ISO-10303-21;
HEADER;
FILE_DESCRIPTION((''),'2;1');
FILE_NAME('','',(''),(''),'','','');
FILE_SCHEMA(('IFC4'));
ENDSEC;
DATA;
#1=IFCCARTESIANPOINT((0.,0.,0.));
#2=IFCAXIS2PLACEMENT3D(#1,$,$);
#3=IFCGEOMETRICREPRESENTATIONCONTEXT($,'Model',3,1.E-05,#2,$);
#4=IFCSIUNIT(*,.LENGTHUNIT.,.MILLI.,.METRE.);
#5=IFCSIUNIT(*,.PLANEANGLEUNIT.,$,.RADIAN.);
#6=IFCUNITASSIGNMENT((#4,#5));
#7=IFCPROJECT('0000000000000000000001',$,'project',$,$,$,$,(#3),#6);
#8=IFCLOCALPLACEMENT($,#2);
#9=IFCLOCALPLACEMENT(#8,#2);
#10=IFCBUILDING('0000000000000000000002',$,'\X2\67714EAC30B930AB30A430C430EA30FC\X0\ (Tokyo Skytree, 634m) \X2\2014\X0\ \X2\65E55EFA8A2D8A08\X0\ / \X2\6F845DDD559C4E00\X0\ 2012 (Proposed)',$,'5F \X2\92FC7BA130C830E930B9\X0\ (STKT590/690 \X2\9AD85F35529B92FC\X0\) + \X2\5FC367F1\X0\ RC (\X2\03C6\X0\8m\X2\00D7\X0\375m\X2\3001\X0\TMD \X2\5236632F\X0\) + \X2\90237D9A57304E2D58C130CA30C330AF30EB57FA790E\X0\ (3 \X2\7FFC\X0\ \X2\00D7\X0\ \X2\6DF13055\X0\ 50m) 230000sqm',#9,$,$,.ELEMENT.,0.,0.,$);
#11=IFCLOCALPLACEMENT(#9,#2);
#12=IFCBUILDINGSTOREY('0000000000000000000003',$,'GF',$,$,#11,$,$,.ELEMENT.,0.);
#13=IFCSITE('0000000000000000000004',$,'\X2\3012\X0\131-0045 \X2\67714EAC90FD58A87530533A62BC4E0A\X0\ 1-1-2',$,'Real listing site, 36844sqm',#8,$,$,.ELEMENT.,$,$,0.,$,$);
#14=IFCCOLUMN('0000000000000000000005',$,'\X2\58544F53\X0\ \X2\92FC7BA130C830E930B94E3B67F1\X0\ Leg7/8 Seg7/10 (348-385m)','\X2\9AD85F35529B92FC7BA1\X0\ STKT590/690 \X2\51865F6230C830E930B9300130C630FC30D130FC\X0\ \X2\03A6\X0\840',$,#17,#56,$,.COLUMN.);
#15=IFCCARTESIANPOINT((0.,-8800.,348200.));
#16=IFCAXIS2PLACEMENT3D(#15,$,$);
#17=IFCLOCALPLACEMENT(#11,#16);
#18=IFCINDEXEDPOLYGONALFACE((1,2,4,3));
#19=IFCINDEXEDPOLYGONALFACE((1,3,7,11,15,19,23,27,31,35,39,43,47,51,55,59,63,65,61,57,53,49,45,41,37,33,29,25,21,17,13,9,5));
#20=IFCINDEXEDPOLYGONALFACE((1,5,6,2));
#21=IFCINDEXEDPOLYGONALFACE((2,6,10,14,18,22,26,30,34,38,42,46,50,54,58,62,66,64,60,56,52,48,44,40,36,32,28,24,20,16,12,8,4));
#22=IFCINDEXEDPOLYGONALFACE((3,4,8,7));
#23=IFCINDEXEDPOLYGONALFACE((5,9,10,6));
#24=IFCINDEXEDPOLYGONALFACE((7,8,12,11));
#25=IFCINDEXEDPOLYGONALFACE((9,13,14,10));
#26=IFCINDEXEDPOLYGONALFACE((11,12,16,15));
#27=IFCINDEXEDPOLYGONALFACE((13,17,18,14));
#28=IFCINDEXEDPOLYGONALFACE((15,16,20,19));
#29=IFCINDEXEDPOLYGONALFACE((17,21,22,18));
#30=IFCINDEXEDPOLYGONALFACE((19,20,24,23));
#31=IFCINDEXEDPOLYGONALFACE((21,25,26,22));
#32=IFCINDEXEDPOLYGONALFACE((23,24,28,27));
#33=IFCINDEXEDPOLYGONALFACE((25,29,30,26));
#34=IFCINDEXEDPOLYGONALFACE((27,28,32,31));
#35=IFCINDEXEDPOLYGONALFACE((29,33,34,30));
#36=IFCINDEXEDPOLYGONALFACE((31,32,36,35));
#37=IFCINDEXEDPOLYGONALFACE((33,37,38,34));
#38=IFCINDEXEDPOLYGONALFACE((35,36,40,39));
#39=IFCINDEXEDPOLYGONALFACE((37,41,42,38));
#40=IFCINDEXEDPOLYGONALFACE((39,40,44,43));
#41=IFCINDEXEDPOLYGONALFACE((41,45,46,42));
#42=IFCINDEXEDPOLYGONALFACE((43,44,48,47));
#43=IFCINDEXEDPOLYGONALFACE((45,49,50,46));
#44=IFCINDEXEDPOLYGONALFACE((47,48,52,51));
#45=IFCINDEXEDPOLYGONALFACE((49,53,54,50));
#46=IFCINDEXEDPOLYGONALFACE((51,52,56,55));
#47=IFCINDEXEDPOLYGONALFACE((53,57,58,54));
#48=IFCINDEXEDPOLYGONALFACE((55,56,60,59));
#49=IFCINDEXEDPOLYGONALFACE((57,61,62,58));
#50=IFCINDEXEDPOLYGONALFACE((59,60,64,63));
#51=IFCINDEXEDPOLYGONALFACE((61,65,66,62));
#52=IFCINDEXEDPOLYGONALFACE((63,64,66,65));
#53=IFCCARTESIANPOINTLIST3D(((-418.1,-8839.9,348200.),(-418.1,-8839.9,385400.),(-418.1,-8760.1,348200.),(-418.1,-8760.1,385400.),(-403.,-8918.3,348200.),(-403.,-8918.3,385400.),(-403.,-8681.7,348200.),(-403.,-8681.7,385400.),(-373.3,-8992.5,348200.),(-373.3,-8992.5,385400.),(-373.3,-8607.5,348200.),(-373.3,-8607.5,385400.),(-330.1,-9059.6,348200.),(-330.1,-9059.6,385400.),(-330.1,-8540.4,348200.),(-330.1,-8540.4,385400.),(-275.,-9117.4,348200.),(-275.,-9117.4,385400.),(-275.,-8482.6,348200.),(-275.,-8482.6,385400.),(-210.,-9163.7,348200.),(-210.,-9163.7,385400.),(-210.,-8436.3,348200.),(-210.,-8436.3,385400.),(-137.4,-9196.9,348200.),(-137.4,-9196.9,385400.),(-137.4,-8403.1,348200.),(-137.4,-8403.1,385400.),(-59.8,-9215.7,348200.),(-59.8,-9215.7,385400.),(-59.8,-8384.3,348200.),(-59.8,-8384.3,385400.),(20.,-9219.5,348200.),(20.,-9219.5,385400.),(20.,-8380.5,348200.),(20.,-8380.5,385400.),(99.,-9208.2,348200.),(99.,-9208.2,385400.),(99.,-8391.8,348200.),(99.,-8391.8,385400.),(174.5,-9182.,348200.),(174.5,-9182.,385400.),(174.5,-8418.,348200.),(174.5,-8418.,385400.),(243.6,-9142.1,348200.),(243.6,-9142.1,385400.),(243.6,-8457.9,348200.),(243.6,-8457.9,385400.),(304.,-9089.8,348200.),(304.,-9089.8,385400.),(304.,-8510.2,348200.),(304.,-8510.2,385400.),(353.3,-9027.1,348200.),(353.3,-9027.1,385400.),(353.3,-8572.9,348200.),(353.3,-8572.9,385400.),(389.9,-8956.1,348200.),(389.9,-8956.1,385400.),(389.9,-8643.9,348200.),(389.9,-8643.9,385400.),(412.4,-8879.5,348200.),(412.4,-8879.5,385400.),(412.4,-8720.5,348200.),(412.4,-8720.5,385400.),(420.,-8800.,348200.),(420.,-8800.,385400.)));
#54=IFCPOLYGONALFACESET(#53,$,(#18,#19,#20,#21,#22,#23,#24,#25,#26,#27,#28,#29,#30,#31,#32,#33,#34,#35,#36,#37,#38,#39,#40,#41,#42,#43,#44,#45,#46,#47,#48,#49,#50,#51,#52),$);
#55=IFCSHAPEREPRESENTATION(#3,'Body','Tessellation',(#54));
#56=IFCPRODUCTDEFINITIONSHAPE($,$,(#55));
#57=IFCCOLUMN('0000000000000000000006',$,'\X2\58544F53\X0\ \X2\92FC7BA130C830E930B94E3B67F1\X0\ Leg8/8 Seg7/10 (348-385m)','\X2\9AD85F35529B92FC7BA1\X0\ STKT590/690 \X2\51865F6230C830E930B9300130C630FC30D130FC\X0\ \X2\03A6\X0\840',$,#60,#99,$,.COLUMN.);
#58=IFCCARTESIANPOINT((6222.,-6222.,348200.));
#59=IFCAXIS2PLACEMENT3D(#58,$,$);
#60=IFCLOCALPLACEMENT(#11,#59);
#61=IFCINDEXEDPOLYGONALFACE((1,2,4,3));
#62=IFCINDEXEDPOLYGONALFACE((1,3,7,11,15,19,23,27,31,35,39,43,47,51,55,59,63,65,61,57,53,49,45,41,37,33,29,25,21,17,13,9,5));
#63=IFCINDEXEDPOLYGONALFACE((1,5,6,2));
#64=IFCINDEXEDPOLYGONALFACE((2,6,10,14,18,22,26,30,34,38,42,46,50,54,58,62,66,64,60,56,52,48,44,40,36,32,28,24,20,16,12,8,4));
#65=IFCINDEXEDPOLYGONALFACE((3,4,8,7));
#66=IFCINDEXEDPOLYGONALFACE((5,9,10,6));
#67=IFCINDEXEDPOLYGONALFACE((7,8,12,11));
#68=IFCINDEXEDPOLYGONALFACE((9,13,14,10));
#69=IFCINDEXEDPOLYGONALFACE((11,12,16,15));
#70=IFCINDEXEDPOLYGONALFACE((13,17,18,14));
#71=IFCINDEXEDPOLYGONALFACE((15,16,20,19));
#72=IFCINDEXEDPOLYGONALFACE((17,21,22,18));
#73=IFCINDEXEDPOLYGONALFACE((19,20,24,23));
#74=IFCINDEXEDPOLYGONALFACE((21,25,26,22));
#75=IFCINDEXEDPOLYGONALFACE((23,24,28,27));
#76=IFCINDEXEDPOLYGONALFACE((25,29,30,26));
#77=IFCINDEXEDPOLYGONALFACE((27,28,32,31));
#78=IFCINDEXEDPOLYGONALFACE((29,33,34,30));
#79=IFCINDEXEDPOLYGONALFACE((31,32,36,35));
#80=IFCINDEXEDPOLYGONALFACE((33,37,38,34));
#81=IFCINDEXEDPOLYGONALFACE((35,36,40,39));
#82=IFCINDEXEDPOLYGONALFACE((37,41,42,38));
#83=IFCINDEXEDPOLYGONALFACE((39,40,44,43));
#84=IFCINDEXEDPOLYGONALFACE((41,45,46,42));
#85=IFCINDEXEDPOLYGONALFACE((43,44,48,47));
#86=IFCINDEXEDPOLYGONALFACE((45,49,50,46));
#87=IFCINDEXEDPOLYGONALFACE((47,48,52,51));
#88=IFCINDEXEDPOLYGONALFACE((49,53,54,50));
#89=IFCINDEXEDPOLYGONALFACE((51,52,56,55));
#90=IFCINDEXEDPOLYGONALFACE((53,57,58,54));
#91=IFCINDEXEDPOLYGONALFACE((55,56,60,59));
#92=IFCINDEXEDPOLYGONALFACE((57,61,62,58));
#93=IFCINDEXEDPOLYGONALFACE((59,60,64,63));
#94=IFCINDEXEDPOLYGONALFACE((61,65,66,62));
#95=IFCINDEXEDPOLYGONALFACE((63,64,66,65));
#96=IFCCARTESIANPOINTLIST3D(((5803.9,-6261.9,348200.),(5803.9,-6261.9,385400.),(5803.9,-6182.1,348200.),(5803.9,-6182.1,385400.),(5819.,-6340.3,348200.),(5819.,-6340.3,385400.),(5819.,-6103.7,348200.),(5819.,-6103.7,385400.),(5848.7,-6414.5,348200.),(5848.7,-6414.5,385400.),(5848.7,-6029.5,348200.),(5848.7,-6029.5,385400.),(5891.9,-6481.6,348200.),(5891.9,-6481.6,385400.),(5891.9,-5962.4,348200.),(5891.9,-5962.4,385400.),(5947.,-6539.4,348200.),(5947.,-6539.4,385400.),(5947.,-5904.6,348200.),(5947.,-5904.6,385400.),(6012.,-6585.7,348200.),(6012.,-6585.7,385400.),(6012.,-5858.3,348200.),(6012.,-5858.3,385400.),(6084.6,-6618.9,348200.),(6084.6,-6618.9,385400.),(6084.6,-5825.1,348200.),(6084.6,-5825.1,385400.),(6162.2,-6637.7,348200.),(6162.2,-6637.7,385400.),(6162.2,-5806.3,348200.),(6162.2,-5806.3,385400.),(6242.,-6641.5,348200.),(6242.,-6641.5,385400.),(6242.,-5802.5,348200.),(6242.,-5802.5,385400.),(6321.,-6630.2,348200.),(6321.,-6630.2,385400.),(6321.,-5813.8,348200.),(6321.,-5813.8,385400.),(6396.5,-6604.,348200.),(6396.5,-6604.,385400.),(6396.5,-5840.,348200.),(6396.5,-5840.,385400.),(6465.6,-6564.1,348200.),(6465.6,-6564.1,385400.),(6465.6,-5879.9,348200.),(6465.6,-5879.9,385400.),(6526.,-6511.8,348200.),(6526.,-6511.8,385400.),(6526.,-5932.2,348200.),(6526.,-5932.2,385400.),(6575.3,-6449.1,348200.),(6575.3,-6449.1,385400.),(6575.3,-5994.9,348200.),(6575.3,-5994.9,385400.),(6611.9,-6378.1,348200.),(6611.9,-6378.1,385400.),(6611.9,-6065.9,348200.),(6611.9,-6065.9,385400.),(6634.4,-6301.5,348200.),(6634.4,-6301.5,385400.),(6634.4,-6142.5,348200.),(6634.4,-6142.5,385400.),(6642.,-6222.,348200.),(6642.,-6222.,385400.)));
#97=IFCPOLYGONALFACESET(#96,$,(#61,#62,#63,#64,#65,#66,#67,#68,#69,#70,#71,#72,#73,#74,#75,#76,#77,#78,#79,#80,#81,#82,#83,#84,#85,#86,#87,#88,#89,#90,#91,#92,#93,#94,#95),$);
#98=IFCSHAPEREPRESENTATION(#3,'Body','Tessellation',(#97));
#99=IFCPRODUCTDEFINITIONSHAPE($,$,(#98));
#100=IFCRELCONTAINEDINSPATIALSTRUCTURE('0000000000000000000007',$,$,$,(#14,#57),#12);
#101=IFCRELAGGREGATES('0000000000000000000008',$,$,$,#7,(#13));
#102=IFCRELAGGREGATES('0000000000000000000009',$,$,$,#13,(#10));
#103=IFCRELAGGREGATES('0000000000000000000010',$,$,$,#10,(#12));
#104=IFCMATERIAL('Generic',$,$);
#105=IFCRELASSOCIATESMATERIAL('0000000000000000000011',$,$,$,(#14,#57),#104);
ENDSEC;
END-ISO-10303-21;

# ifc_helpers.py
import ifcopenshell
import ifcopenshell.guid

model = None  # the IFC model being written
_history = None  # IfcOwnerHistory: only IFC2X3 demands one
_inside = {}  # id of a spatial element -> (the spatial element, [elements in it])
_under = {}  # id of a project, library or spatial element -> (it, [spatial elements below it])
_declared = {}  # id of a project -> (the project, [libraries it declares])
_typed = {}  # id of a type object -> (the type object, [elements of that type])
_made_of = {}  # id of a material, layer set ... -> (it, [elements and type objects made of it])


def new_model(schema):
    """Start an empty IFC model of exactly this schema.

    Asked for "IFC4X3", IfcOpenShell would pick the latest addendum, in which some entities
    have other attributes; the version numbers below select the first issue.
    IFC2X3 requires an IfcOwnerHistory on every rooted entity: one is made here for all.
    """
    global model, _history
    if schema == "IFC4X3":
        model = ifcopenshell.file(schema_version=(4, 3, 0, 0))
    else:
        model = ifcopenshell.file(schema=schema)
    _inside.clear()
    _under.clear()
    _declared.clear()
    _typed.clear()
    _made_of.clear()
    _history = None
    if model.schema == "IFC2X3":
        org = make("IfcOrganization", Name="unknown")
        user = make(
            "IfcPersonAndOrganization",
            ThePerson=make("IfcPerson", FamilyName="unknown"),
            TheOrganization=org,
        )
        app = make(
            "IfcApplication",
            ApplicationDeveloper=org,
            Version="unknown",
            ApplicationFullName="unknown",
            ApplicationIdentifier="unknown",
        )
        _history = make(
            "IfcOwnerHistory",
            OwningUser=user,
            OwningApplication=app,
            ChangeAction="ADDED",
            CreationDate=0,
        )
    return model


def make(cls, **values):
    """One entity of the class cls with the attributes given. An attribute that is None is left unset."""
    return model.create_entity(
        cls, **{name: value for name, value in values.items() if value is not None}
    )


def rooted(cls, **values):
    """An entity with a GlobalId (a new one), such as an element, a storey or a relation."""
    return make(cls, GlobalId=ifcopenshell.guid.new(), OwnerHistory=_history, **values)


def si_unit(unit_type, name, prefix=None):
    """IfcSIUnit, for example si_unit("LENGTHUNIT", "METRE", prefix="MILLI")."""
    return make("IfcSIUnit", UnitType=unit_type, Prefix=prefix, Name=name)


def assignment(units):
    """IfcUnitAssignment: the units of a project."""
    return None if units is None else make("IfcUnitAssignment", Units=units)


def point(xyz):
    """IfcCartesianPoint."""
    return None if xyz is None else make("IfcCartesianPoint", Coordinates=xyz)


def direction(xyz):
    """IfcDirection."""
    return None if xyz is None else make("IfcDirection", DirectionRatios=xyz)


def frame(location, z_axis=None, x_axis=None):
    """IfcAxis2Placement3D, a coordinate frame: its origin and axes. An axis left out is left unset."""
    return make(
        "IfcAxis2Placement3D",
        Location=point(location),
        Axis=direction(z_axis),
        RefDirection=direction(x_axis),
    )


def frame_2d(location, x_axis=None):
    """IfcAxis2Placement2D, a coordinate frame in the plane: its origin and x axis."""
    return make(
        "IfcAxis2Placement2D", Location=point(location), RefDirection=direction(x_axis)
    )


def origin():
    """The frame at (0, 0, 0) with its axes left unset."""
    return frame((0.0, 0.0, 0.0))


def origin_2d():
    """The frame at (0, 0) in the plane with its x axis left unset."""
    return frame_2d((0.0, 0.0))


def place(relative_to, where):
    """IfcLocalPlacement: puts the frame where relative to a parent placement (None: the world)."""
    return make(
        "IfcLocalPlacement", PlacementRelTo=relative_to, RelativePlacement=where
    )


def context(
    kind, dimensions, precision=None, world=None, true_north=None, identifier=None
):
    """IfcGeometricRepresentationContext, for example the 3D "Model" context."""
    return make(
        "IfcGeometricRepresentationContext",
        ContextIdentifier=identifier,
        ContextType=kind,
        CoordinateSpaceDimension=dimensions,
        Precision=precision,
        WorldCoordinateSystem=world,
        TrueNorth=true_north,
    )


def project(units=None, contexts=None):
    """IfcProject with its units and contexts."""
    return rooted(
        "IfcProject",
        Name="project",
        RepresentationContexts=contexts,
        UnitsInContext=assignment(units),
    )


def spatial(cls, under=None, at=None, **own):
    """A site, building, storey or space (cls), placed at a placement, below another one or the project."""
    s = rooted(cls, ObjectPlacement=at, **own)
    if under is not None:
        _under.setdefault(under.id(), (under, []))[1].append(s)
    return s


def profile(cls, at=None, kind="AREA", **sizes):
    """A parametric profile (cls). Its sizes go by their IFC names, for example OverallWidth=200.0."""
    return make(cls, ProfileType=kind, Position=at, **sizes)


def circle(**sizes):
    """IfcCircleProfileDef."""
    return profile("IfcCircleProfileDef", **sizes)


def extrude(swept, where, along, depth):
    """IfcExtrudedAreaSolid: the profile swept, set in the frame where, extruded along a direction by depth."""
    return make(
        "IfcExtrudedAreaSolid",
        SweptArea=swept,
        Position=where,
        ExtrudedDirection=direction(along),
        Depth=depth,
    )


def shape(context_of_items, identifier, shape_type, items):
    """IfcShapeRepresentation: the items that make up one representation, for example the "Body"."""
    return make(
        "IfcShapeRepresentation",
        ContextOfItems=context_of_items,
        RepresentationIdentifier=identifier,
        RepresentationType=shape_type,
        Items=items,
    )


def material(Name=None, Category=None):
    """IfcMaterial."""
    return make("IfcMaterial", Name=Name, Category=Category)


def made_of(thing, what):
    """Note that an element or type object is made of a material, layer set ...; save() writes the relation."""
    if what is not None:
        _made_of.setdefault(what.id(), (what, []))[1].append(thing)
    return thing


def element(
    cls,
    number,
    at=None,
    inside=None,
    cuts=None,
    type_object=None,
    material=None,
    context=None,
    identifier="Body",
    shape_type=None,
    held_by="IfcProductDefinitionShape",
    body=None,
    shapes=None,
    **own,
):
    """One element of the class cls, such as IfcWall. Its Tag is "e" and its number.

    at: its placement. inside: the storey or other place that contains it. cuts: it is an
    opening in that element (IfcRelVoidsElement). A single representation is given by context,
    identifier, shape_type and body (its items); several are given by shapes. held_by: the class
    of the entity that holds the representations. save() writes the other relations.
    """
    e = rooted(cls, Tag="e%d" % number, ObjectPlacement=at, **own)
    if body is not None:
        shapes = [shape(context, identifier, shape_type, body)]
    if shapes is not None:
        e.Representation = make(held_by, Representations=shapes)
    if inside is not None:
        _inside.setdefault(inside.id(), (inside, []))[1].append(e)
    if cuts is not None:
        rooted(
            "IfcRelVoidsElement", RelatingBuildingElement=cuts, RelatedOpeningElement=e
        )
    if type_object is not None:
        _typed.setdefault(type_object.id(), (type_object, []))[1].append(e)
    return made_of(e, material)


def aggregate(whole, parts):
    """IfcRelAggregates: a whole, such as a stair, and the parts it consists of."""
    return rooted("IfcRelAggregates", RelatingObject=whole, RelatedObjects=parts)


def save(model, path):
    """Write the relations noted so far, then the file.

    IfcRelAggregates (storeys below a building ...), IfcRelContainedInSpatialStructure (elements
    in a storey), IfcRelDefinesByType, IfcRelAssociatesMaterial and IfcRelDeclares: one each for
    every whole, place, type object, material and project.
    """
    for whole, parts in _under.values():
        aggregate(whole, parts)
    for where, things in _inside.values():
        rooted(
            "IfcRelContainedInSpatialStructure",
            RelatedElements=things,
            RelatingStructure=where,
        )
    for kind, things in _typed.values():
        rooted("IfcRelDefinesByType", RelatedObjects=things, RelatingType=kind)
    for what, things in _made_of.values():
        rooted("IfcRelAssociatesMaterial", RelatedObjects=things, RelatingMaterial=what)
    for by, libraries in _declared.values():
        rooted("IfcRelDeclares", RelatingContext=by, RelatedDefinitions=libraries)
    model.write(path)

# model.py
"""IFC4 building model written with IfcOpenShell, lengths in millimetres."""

from ifc_helpers import new_model, si_unit, frame, origin, origin_2d, place, context, project, spatial, circle, extrude, material, element, save


model = new_model("IFC4")

# Units and contexts
model_context = context("Model", 3, precision=1e-05, world=origin())
ifc_project = project(units=[si_unit("LENGTHUNIT", "METRE", prefix="MILLI"), si_unit("PLANEANGLEUNIT", "RADIAN")], contexts=[model_context])

# Site, building, storey
site_placement = place(None, origin())
site = spatial("IfcSite", under=ifc_project, at=site_placement, Name="〒131-0045 東京都墨田区押上 1-1-2", ObjectType="Real listing site, 36844sqm", CompositionType="ELEMENT", RefElevation=0.0)
building_placement = place(site_placement, origin())
building = spatial("IfcBuilding", under=site, at=building_placement, Name="東京スカイツリー (Tokyo Skytree, 634m) — 日建設計 / 澄川喜一 2012 (Proposed)", ObjectType="5F 鋼管トラス (STKT590/690 高張力鋼) + 心柱 RC (φ8m×375m、TMD 制振) + 連続地中壁ナックル基礎 (3 翼 × 深さ 50m) 230000sqm", CompositionType="ELEMENT", ElevationOfRefHeight=0.0, ElevationOfTerrain=0.0)
storey_placement = place(building_placement, origin())
storey = spatial("IfcBuildingStorey", under=building, at=storey_placement, Name="GF", CompositionType="ELEMENT", Elevation=0.0)

# Columns
ifc_material_1 = material(Name="Generic")
column_1_placement = place(storey_placement, frame((0.0, -8800.0, 348200.0)))
element("IfcColumn", 1, at=column_1_placement, inside=storey, material=ifc_material_1, Name="塔体 鋼管トラス主柱 Leg7/8 Seg7/10 (348-385m)", Description="高張力鋼管 STKT590/690 円形トラス、テーパー Φ840", PredefinedType="COLUMN", context=model_context, shape_type="SweptSolid", body=[
    extrude(circle(Radius=420.0, at=origin_2d()), frame((0.0, -8800.0, 348200.0)), (0.0, 0.0, 1.0), 37200.0),
])
column_2_placement = place(storey_placement, frame((6222.0, -6222.0, 348200.0)))
element("IfcColumn", 2, at=column_2_placement, inside=storey, material=ifc_material_1, Name="塔体 鋼管トラス主柱 Leg8/8 Seg7/10 (348-385m)", Description="高張力鋼管 STKT590/690 円形トラス、テーパー Φ840", PredefinedType="COLUMN", context=model_context, shape_type="SweptSolid", body=[
    extrude(circle(Radius=420.0, at=origin_2d()), frame((6222.0, -6222.0, 348200.0)), (0.0, 0.0, 1.0), 37200.0),
])

save(model, "model.ifc")
